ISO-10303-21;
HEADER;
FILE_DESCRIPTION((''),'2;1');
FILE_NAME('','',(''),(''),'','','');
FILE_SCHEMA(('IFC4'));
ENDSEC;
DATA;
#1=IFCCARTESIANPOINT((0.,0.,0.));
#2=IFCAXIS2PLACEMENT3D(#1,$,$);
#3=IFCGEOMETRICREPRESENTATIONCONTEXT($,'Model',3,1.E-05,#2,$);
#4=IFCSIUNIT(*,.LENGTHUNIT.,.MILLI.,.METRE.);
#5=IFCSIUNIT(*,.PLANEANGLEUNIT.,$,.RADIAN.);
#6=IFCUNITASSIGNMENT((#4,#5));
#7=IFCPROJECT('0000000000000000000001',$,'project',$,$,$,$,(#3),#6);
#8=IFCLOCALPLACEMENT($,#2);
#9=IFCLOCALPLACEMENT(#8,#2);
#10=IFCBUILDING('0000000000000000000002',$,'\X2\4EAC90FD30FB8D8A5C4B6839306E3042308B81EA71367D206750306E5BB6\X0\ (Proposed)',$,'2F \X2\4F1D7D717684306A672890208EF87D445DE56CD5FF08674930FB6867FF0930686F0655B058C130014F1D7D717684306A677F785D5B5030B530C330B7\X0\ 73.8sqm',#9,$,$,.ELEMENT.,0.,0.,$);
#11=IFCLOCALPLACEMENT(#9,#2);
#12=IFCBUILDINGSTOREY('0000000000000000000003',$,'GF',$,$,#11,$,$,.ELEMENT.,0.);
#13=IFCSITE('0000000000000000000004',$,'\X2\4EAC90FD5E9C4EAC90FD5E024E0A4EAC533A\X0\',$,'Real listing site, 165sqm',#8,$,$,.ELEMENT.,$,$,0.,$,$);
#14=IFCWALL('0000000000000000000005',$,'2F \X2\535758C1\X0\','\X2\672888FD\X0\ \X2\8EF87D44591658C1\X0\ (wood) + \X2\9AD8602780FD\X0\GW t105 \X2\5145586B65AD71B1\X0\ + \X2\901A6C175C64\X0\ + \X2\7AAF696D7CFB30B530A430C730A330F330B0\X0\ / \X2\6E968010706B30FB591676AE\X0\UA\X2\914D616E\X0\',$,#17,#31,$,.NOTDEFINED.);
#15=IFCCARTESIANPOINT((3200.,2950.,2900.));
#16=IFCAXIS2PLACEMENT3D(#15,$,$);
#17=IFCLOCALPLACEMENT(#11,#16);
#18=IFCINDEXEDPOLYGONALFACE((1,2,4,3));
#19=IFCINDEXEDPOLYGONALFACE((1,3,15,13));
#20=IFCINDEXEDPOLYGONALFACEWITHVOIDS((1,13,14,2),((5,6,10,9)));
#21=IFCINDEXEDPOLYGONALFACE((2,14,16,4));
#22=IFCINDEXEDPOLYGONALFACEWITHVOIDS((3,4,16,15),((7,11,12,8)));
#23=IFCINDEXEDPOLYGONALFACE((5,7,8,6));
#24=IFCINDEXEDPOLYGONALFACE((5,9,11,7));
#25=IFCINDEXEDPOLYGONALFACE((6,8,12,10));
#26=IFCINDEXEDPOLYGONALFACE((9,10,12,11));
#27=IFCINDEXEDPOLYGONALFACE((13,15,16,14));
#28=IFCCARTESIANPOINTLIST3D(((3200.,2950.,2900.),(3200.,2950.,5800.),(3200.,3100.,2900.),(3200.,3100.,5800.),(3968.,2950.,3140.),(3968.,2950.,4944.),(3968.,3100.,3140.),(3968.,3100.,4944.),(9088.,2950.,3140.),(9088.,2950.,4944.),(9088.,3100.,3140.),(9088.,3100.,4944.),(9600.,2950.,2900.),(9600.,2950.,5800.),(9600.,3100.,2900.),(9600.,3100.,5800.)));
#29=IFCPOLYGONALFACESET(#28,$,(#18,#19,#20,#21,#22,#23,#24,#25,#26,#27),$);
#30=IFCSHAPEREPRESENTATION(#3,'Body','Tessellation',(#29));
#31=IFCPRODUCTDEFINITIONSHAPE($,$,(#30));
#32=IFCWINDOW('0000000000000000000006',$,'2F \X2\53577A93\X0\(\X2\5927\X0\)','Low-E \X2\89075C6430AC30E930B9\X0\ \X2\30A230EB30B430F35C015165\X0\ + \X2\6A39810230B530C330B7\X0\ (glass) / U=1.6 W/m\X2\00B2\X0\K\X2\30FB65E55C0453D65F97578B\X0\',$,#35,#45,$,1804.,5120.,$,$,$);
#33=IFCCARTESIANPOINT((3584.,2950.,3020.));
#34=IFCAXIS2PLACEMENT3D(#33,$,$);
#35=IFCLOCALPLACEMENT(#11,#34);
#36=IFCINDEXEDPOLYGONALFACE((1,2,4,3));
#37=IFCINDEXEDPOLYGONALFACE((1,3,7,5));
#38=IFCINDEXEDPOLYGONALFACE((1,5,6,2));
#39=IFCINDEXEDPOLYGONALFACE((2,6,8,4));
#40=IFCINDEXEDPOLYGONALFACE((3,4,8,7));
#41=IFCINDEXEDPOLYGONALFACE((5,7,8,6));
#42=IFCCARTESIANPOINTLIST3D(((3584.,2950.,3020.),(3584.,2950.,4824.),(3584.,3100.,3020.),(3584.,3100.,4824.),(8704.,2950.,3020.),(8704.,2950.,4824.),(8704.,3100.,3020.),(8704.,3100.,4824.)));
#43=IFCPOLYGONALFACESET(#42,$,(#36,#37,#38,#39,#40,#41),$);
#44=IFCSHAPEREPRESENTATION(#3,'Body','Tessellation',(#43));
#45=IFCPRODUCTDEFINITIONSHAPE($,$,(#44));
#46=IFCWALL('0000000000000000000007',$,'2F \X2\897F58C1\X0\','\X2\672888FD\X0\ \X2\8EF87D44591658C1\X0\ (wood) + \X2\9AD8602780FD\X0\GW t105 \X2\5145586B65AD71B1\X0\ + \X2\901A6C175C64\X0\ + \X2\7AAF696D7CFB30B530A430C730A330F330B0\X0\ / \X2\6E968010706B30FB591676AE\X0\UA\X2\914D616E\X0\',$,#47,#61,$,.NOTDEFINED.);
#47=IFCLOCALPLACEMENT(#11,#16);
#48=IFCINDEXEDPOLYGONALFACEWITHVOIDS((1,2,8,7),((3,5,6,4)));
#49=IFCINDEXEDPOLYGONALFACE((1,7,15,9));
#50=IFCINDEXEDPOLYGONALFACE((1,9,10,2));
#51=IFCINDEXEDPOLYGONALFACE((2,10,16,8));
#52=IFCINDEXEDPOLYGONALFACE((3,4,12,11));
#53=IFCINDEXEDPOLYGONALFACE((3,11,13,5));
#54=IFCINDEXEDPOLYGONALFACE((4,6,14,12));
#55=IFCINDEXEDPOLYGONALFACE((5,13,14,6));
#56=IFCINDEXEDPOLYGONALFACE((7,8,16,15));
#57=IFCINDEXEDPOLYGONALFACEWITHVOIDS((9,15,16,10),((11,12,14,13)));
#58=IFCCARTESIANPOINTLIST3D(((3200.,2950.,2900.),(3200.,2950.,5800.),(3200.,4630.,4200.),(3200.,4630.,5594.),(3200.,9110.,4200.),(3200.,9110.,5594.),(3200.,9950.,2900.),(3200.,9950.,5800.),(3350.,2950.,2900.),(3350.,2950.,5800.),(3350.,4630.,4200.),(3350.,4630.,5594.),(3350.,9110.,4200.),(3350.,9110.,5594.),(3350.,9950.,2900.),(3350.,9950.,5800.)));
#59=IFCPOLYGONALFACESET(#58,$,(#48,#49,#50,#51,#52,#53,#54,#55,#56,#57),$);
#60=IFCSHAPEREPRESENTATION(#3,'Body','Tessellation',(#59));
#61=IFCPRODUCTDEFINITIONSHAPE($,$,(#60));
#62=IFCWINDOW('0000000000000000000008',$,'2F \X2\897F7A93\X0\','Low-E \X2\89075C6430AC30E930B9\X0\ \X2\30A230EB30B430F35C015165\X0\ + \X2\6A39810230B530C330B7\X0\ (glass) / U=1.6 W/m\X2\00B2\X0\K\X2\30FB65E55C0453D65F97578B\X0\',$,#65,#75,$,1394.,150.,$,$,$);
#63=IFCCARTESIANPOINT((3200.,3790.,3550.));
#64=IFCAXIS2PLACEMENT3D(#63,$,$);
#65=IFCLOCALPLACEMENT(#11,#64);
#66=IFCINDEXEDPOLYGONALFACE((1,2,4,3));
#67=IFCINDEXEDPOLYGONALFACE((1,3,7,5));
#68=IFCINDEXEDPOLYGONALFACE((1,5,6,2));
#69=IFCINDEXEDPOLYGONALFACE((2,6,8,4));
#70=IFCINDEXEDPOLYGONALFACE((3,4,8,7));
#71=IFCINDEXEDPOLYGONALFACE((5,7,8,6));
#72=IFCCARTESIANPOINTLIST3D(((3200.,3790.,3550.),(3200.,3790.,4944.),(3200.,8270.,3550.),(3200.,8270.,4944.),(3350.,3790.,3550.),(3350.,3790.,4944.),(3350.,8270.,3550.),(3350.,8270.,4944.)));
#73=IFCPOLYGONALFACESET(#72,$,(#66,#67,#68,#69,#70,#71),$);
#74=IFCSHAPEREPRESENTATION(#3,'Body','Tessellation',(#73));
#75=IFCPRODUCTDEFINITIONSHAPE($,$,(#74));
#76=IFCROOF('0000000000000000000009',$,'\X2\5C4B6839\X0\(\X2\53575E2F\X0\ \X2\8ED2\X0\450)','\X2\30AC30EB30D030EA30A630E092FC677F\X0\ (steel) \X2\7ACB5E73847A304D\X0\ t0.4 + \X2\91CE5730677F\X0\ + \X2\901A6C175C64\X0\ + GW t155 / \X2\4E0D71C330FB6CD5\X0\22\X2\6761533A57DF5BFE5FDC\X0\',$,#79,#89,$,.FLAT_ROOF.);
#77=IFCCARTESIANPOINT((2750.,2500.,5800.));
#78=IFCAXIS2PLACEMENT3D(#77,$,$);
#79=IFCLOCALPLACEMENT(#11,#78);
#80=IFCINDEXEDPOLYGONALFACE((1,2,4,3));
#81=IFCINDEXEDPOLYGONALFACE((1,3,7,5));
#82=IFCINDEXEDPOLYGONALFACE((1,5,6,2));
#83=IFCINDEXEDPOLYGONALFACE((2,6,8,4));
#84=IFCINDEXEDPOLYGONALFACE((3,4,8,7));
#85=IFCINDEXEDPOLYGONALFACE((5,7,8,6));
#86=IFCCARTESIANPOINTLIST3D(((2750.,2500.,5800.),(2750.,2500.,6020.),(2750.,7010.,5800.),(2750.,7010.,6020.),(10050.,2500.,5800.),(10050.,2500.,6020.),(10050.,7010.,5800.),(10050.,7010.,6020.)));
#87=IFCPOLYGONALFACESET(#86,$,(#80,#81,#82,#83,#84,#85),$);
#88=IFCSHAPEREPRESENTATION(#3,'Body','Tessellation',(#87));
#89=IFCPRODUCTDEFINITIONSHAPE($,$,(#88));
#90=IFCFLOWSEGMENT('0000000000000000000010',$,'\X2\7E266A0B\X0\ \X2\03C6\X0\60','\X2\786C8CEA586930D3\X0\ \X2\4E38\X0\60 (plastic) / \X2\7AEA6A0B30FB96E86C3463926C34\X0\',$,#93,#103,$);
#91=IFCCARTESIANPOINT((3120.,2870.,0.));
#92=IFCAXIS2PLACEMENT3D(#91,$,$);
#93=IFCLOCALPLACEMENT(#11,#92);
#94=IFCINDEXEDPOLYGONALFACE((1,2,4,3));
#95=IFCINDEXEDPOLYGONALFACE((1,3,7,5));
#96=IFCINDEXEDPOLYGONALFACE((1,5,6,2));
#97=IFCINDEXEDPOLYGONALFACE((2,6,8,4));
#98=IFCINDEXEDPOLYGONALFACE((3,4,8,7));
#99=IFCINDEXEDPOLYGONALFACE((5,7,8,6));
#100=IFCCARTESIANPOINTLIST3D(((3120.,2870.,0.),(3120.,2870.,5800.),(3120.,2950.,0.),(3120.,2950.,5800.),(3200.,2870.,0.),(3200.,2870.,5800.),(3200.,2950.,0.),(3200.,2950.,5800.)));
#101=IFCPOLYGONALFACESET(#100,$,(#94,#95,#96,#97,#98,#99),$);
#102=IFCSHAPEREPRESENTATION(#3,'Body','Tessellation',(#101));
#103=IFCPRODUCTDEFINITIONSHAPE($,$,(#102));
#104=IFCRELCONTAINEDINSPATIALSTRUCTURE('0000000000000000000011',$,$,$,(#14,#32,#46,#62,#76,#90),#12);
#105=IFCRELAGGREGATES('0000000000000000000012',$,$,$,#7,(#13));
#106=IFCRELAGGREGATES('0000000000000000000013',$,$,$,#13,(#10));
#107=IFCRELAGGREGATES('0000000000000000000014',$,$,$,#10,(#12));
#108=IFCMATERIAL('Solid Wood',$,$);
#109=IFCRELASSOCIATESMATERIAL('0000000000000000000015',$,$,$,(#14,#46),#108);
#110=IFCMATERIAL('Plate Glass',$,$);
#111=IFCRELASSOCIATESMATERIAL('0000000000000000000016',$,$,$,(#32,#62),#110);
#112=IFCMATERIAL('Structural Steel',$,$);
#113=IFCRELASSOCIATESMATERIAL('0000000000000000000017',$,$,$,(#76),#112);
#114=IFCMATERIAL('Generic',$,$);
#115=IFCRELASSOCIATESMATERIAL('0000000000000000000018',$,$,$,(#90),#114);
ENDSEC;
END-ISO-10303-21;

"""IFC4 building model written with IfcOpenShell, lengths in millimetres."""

from ifc_helpers import new_model, si_unit, frame, frame_2d, origin, place, context, project, spatial, rectangle, extrude, material, element, fill, save


model = new_model("IFC4")

# Units and contexts
model_context = context("Model", 3, precision=1e-05, world=origin())
ifc_project = project(units=[si_unit("LENGTHUNIT", "METRE", prefix="MILLI"), si_unit("PLANEANGLEUNIT", "RADIAN")], contexts=[model_context])

# Site, building, storey
site_placement = place(None, origin())
site = spatial("IfcSite", under=ifc_project, at=site_placement, Name="京都府京都市上京区", ObjectType="Real listing site, 165sqm", CompositionType="ELEMENT", RefElevation=0.0)
building_placement = place(site_placement, origin())
building = spatial("IfcBuilding", under=site, at=building_placement, Name="京都・越屋根のある自然素材の家 (Proposed)", ObjectType="2F 伝統的な木造軸組工法（杉・桧）と漆喰壁、伝統的な板硝子サッシ 73.8sqm", CompositionType="ELEMENT", ElevationOfRefHeight=0.0, ElevationOfTerrain=0.0)
storey_placement = place(building_placement, origin())
storey = spatial("IfcBuildingStorey", under=building, at=storey_placement, Name="GF", CompositionType="ELEMENT", Elevation=0.0)

# Shared definitions
ifc_material_1 = material(Name="Solid Wood")

# Shared definitions
ifc_material_2 = material(Name="Plate Glass")

# Walls, openings, windows
wall_1_placement = place(storey_placement, frame((3200.0, 2950.0, 2900.0)))
wall_1 = element("IfcWall", 1, at=wall_1_placement, inside=storey, material=ifc_material_1, Name="2F 南壁", Description="木製 軸組外壁 (wood) + 高性能GW t105 充填断熱 + 通気層 + 窯業系サイディング / 準耐火・外皮UA配慮", PredefinedType="NOTDEFINED", context=model_context, shape_type="SweptSolid", body=[
    extrude(rectangle(XDim=6400.0, YDim=150.0, at=frame_2d((3200.0, 75.0))), frame((3200.0, 2950.0, 2900.0)), (0.0, 0.0, 1.0), 2900.0),
])
opening_1_placement = place(storey_placement, frame((3584.0, 2950.0, 3020.0)))
opening_1 = element("IfcOpeningElement", 2, at=opening_1_placement, cuts=wall_1, PredefinedType="NOTDEFINED", context=model_context, shape_type="SweptSolid", body=[
    extrude(rectangle(XDim=5120.0, YDim=150.0, at=frame_2d((2560.0, 75.0))), frame((3584.0, 2950.0, 3020.0)), (0.0, 0.0, 1.0), 1804.0),
])
window_1_placement = place(storey_placement, frame((3584.0, 2950.0, 3020.0)))
window_1 = element("IfcWindow", 3, at=window_1_placement, inside=storey, material=ifc_material_2, Name="2F 南窓(大)", Description="Low-E 複層ガラス アルゴン封入 + 樹脂サッシ (glass) / U=1.6 W/m²K・日射取得型", OverallHeight=1804.0, OverallWidth=5120.0, context=model_context, shape_type="SweptSolid", body=[
    extrude(rectangle(XDim=5120.0, YDim=150.0, at=frame_2d((2560.0, 75.0))), frame((3584.0, 2950.0, 3020.0)), (0.0, 0.0, 1.0), 1804.0),
])
fill(opening_1, window_1)
wall_2_placement = place(storey_placement, frame((3200.0, 2950.0, 2900.0)))
wall_2 = element("IfcWall", 4, at=wall_2_placement, inside=storey, material=ifc_material_1, Name="2F 西壁", Description="木製 軸組外壁 (wood) + 高性能GW t105 充填断熱 + 通気層 + 窯業系サイディング / 準耐火・外皮UA配慮", PredefinedType="NOTDEFINED", context=model_context, shape_type="SweptSolid", body=[
    extrude(rectangle(XDim=150.0, YDim=7000.0, at=frame_2d((75.0, 3500.0))), frame((3200.0, 2950.0, 2900.0)), (0.0, 0.0, 1.0), 2900.0),
])
opening_2_placement = place(storey_placement, frame((3200.0, 3790.0, 3550.0)))
opening_2 = element("IfcOpeningElement", 5, at=opening_2_placement, cuts=wall_2, PredefinedType="NOTDEFINED", context=model_context, shape_type="SweptSolid", body=[
    extrude(rectangle(XDim=150.0, YDim=4480.0, at=frame_2d((75.0, 2240.0))), frame((3200.0, 3790.0, 3550.0)), (0.0, 0.0, 1.0), 1394.0),
])
window_2_placement = place(storey_placement, frame((3200.0, 3790.0, 3550.0)))
window_2 = element("IfcWindow", 6, at=window_2_placement, inside=storey, material=ifc_material_2, Name="2F 西窓", Description="Low-E 複層ガラス アルゴン封入 + 樹脂サッシ (glass) / U=1.6 W/m²K・日射取得型", OverallHeight=1394.0, OverallWidth=150.0, context=model_context, shape_type="SweptSolid", body=[
    extrude(rectangle(XDim=150.0, YDim=4480.0, at=frame_2d((75.0, 2240.0))), frame((3200.0, 3790.0, 3550.0)), (0.0, 0.0, 1.0), 1394.0),
])
fill(opening_2, window_2)

# Roof
ifc_material_3 = material(Name="Structural Steel")
for number, where, name in (
    (7, (2750.0, 2500.0, 5800.0), "屋根(南帯 軒450)"),
):
    element("IfcRoof", number, at=place(storey_placement, frame(where)), inside=storey, material=ifc_material_3, Name=name, Description="ガルバリウム鋼板 (steel) 立平葺き t0.4 + 野地板 + 通気層 + GW t155 / 不燃・法22条区域対応", PredefinedType="FLAT_ROOF", context=model_context, shape_type="SweptSolid", body=[
        extrude(rectangle(XDim=7300.0, YDim=4510.0, at=frame_2d((3650.0, 2255.0))), frame((2750.0, 2500.0, 5800.0)), (0.0, 0.0, 1.0), 220.0),
    ])

# Flow segment
ifc_material_4 = material(Name="Generic")
flow_segment_1_placement = place(storey_placement, frame((3120.0, 2870.0, 0.0)))
element("IfcFlowSegment", 8, at=flow_segment_1_placement, inside=storey, material=ifc_material_4, Name="縦樋 φ60", Description="硬質塩ビ 丸60 (plastic) / 竪樋・雨水排水", context=model_context, shape_type="SweptSolid", body=[
    extrude(rectangle(XDim=80.0, YDim=80.0, at=frame_2d((40.0, 40.0))), frame((3120.0, 2870.0, 0.0)), (0.0, 0.0, 1.0), 5800.0),
])

save(model, "model.ifc")
